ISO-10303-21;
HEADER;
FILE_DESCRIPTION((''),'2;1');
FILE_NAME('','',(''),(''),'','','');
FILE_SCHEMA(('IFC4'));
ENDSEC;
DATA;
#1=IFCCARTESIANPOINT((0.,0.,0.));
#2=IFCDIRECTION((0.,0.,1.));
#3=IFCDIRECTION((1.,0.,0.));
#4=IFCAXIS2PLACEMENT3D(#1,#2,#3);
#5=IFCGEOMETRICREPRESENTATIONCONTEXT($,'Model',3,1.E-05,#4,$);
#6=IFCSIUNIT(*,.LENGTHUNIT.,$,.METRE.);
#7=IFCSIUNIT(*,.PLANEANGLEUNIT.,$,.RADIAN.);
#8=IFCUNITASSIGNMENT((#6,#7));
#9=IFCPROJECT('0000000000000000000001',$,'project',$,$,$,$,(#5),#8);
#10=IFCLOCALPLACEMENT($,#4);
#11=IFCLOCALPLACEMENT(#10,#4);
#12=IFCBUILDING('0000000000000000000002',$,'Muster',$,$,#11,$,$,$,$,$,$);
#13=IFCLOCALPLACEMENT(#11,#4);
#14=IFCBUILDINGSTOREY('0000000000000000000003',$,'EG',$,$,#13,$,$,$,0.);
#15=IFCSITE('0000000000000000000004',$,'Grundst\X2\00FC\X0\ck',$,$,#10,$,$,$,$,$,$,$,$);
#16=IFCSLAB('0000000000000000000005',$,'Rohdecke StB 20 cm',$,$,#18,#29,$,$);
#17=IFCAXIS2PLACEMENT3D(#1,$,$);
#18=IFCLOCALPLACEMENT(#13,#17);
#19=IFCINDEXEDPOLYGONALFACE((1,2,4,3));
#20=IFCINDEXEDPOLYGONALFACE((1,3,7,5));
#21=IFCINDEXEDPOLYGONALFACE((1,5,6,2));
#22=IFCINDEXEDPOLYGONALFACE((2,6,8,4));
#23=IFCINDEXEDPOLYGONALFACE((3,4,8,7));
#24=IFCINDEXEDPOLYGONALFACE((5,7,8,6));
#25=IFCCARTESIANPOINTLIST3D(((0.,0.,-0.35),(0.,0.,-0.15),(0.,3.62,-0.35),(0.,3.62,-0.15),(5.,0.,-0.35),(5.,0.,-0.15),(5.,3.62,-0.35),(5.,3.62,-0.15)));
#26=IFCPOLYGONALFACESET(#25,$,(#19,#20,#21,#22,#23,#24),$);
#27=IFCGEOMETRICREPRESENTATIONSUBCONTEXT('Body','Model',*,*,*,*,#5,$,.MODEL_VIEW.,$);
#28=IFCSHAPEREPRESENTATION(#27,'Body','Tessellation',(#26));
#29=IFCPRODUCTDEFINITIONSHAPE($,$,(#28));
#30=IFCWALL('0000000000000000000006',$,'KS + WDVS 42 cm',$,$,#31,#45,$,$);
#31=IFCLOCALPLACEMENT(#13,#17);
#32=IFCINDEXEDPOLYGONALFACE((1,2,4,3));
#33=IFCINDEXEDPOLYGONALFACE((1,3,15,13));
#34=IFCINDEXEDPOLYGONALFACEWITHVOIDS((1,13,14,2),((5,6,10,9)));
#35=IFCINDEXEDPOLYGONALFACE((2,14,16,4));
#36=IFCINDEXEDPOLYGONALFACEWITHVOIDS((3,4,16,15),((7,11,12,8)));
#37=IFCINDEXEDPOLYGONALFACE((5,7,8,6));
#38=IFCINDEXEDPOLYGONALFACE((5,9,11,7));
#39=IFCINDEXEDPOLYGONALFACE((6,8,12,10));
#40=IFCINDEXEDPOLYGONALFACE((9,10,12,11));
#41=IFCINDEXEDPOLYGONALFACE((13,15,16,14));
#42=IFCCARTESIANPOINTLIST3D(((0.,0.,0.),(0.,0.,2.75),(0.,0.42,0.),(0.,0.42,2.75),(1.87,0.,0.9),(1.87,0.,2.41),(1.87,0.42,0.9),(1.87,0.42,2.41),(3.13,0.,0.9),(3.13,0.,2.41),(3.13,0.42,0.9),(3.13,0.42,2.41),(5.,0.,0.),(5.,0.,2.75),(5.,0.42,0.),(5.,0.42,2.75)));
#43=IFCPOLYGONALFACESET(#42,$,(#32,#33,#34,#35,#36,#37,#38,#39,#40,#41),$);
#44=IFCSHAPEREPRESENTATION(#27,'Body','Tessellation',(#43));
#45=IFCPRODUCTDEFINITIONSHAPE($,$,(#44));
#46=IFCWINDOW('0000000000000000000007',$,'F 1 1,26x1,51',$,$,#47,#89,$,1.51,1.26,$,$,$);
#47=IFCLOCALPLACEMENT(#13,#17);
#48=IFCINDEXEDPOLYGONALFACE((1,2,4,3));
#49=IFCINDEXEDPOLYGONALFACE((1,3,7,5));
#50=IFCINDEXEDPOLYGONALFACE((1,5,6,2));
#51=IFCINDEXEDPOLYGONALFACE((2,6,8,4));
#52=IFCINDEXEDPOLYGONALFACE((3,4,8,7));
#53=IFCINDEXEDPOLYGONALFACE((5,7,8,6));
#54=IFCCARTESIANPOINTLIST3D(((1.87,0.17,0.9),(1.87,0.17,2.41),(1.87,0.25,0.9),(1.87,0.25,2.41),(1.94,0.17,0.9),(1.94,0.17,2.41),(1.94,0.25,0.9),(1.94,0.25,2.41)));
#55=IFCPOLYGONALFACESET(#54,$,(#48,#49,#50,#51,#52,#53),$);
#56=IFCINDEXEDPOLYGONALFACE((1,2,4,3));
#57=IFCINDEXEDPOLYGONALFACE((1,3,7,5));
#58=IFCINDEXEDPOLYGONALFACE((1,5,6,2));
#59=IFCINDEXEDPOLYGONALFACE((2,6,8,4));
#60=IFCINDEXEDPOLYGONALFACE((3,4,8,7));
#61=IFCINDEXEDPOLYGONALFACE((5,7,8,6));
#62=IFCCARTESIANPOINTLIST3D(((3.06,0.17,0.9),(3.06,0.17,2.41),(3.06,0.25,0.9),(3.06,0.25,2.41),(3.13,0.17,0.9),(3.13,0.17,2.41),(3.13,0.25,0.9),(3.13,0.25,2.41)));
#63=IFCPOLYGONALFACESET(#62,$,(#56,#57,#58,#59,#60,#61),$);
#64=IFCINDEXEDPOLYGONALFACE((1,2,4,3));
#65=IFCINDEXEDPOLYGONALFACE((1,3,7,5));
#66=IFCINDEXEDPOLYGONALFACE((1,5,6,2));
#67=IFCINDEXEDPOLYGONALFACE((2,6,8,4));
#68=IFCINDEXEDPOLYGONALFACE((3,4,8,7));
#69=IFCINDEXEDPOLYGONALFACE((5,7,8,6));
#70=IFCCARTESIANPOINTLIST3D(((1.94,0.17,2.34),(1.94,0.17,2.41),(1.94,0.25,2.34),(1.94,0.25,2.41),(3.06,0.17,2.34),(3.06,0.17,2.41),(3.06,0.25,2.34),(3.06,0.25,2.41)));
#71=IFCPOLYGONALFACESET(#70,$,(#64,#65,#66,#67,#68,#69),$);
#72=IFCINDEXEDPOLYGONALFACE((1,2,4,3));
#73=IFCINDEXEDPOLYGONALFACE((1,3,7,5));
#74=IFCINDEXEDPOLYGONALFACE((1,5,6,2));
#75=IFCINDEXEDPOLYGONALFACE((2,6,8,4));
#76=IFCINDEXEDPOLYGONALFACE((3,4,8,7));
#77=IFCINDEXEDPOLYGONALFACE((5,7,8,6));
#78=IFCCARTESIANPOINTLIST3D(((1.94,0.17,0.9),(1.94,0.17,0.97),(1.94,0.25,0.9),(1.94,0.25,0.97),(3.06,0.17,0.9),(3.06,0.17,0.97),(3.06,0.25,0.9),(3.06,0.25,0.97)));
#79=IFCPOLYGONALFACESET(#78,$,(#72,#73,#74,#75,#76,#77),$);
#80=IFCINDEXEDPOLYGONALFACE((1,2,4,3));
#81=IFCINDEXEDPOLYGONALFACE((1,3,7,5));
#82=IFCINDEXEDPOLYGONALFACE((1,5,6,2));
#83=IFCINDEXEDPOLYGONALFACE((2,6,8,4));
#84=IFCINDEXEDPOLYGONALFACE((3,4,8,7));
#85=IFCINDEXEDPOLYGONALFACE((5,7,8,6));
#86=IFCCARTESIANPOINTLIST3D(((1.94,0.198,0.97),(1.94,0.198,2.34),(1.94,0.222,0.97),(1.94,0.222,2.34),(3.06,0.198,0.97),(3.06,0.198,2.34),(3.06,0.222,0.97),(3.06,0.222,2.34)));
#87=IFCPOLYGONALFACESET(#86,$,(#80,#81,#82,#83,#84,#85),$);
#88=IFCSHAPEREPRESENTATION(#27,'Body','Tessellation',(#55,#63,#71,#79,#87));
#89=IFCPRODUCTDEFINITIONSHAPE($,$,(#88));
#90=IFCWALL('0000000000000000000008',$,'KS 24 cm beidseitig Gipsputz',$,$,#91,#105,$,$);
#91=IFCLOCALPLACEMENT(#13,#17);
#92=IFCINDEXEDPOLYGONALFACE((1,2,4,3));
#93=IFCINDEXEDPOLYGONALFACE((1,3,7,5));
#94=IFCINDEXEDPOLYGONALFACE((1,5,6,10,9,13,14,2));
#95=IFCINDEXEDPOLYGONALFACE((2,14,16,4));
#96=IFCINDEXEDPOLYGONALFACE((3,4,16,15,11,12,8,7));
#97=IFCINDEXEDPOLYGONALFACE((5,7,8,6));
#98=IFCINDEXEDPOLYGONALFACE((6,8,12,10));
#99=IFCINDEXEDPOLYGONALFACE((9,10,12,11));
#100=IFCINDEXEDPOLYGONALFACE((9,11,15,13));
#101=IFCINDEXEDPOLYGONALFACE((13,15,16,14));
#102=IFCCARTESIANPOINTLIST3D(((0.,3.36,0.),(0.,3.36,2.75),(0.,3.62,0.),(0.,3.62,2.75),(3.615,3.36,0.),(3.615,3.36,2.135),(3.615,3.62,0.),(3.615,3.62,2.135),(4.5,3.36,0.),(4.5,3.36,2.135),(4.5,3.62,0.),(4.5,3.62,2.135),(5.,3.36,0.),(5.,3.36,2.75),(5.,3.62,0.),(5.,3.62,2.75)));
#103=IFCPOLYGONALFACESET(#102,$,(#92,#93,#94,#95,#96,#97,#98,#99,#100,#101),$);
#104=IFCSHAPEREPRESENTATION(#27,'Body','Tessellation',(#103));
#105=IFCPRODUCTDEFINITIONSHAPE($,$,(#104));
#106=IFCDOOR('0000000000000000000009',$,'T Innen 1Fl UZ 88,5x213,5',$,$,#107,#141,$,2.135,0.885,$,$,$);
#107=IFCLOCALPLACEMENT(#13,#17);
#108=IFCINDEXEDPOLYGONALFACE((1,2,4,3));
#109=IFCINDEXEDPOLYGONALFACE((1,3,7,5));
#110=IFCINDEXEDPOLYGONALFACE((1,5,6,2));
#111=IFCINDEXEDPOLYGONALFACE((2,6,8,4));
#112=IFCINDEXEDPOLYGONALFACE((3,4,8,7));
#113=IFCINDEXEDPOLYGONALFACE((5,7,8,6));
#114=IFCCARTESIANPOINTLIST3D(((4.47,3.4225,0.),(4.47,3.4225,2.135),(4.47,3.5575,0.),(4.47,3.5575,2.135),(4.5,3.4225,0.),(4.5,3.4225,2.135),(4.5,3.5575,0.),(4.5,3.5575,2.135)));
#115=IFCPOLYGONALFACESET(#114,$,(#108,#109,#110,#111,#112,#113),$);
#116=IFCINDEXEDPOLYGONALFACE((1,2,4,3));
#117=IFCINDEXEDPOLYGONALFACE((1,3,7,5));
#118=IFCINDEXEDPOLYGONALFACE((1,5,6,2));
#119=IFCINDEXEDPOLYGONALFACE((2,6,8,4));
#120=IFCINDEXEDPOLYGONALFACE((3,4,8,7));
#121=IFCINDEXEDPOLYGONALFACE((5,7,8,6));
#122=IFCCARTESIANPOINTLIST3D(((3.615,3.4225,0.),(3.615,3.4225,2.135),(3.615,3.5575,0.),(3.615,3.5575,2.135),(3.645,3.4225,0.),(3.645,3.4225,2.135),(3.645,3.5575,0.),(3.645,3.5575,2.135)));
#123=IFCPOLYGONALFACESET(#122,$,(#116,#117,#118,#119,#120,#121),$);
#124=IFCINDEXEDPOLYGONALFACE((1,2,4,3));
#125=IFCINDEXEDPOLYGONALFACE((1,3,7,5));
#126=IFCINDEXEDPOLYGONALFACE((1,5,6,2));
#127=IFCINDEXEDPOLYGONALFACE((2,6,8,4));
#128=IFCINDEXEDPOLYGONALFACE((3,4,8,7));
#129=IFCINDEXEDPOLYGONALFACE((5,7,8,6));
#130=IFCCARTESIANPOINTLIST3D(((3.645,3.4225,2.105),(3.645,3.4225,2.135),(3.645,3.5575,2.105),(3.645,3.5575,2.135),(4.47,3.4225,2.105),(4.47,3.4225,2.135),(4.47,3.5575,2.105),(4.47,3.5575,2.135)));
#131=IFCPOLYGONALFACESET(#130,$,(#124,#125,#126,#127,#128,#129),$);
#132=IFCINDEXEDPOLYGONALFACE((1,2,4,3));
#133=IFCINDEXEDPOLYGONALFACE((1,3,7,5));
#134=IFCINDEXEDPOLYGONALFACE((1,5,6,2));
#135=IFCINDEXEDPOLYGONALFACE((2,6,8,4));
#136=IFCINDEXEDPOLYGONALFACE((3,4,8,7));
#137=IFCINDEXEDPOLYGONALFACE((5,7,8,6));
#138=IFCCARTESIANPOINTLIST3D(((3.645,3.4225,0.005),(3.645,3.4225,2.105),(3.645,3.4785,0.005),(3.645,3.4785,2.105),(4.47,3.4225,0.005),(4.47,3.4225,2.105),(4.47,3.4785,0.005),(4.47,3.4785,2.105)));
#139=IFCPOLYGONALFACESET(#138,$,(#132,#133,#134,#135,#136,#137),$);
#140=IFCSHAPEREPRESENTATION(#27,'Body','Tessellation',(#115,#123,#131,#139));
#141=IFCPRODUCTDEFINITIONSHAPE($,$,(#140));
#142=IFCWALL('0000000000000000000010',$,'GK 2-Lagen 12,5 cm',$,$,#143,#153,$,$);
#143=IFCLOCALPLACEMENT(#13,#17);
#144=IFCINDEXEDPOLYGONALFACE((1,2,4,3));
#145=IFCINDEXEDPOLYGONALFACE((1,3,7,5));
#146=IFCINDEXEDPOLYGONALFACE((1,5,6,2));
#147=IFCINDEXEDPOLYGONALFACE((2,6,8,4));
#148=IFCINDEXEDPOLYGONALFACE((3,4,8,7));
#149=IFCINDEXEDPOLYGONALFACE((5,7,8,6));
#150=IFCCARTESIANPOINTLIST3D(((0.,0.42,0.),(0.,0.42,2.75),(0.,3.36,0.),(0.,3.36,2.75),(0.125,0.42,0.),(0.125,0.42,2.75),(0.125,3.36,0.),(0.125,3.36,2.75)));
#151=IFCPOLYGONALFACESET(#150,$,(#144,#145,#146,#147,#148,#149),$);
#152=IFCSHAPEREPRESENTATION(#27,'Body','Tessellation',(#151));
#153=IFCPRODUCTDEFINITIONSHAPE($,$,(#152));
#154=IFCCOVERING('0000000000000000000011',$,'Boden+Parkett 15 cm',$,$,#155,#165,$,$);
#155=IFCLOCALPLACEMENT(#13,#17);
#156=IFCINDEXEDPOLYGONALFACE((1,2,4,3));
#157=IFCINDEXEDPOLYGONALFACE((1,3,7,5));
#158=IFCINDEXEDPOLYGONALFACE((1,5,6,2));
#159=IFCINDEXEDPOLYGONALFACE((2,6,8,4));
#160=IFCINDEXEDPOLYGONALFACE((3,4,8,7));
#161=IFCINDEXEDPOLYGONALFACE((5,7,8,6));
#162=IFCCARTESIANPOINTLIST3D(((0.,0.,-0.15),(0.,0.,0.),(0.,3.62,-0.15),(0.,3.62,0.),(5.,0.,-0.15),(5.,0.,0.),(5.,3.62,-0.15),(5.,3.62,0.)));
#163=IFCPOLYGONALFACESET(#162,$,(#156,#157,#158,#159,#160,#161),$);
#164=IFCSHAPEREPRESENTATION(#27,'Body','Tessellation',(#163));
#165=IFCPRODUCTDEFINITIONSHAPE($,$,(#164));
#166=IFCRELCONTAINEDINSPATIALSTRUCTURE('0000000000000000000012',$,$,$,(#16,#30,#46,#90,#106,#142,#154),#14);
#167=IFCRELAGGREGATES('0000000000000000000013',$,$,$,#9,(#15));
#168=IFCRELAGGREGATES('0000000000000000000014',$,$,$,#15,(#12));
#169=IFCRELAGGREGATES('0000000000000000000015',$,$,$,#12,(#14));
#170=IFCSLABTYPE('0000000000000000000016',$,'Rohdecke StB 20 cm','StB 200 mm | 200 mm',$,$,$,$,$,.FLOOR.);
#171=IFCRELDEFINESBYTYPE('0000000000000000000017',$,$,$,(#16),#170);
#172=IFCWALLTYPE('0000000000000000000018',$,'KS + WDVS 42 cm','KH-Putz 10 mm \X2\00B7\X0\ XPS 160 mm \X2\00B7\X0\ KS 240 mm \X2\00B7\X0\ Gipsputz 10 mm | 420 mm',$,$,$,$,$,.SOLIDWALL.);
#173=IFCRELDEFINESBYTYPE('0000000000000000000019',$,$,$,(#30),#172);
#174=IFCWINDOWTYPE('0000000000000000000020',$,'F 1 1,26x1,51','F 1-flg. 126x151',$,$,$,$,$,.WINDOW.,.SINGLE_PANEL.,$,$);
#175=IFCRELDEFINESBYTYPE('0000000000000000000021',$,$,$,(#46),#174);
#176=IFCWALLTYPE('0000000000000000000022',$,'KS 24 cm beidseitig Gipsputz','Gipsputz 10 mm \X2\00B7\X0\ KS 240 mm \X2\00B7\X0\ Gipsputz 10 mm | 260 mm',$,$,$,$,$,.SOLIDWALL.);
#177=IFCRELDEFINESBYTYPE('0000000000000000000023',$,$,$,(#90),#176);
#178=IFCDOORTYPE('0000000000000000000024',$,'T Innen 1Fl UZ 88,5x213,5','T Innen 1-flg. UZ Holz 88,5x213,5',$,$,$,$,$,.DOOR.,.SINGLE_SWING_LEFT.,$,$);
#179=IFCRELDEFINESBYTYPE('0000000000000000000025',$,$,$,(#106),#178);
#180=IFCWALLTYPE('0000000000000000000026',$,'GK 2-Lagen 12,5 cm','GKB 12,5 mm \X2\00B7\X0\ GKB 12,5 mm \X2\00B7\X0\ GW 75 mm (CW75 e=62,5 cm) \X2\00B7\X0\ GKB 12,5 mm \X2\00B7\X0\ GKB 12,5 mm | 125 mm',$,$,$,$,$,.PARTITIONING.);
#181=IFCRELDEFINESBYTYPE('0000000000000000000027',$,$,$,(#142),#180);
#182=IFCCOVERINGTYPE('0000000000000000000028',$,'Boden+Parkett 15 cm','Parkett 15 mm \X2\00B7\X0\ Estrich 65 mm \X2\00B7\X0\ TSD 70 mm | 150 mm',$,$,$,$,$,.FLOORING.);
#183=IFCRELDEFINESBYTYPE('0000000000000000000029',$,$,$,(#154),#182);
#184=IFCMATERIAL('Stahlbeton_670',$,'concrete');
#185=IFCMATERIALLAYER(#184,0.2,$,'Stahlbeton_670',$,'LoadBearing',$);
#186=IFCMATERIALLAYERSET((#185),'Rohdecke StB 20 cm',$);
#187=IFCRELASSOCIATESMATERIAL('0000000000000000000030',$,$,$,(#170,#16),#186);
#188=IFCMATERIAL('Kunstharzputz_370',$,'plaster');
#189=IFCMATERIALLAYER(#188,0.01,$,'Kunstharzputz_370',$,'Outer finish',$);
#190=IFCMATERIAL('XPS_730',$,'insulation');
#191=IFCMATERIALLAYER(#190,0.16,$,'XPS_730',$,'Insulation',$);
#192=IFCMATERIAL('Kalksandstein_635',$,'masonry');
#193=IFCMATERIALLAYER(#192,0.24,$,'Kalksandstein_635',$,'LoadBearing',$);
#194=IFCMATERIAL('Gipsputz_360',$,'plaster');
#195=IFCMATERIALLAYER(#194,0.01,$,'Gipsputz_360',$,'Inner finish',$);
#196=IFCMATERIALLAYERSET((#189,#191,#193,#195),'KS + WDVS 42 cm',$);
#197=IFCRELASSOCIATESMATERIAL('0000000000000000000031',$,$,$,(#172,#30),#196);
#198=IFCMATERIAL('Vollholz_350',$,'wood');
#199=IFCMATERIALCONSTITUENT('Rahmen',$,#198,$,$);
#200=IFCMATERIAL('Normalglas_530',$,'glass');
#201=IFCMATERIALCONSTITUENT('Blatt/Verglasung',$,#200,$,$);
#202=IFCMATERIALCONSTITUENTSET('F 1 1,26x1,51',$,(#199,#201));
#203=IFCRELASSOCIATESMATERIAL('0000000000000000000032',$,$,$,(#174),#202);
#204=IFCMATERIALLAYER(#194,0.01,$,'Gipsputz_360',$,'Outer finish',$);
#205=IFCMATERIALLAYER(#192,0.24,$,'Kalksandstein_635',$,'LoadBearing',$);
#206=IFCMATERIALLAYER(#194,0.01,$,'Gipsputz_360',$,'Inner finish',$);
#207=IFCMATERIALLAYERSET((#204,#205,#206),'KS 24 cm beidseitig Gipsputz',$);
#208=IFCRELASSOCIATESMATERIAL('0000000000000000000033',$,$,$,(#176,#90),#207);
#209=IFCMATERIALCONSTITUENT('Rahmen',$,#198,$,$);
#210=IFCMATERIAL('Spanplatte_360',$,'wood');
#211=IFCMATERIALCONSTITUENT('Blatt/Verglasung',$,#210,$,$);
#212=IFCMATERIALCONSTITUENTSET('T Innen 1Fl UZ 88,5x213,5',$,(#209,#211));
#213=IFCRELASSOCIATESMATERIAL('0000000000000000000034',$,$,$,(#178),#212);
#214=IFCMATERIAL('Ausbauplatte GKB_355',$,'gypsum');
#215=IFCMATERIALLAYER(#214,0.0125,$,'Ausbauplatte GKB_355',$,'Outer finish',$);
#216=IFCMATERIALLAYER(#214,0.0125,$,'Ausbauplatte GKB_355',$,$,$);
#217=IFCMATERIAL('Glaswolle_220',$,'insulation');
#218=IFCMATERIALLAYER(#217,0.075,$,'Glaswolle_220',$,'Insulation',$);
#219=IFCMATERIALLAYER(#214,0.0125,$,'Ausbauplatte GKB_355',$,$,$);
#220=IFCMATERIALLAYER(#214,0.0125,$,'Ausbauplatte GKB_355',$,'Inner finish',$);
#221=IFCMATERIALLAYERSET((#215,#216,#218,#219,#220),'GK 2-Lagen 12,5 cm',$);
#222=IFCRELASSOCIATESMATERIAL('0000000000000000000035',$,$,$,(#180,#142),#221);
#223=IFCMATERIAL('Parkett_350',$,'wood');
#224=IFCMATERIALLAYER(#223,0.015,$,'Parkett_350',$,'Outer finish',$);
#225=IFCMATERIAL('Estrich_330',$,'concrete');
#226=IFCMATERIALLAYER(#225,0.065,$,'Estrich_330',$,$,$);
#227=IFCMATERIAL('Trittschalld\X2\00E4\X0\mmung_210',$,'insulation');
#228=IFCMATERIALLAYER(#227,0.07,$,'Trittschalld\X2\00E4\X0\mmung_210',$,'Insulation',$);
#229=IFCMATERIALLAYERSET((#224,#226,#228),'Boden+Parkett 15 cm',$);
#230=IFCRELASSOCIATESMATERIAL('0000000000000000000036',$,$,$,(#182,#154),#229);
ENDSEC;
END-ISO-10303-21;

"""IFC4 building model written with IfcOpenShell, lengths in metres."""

from ifc_helpers import new_model, si_unit, frame, frame_2d, origin, origin_with_axes, place, context, subcontext, project, spatial, rectangle, extrude, source, transform, mapped, material, layer, layer_set, layer_usage, constituent, constituent_set, type_object, type_shapes, element, fill, save


model = new_model("IFC4")

# Units and contexts
model_context = context("Model", 3, precision=1e-05, world=origin_with_axes())
body_context = subcontext(model_context, "Body", "Model", "MODEL_VIEW")
ifc_project = project(units=[si_unit("LENGTHUNIT", "METRE"), si_unit("PLANEANGLEUNIT", "RADIAN")], contexts=[model_context])

# Site, building, storey
site_placement = place(None, origin_with_axes())
site = spatial("IfcSite", under=ifc_project, at=site_placement, Name="Grundstück")
building_placement = place(site_placement, origin_with_axes())
building = spatial("IfcBuilding", under=site, at=building_placement, Name="Muster")
storey_placement = place(building_placement, origin_with_axes())
storey = spatial("IfcBuildingStorey", under=building, at=storey_placement, Name="EG", Elevation=0.0)

# Slab
ifc_material_1 = material(Name="Stahlbeton_670", Category="concrete")
ifc_layer_1 = layer(ifc_material_1, 0.2, Name="Stahlbeton_670", Category="LoadBearing")
ifc_layer_set_1 = layer_set([ifc_layer_1], Name="Rohdecke StB 20 cm")
ifc_layer_usage_1 = layer_usage(ifc_layer_set_1, "AXIS3", "NEGATIVE", 0.0)
slab_type = type_object("IfcSlabType", Name="Rohdecke StB 20 cm", Description="StB 200 mm | 200 mm", PredefinedType="FLOOR", material=ifc_layer_set_1)
slab_placement = place(storey_placement, frame((0.0, 0.0, -0.15), z_axis=(0.0, 0.0, 1.0), x_axis=(1.0, 0.0, 0.0)))
element("IfcSlab", 1, at=slab_placement, inside=storey, type_object=slab_type, material=ifc_layer_usage_1, Name="Rohdecke StB 20 cm", context=body_context, shape_type="SweptSolid", body=[
    extrude(rectangle(XDim=5.0, YDim=3.62, at=frame_2d((2.5, 1.81))), origin(), (0.0, 0.0, -1.0), 0.2),
])

# Wall, opening, window
ifc_material_2 = material(Name="Kunstharzputz_370", Category="plaster")
ifc_layer_2 = layer(ifc_material_2, 0.01, Name="Kunstharzputz_370", Category="Outer finish")
ifc_material_3 = material(Name="XPS_730", Category="insulation")
ifc_layer_3 = layer(ifc_material_3, 0.16, Name="XPS_730", Category="Insulation")
ifc_material_4 = material(Name="Kalksandstein_635", Category="masonry")
ifc_layer_4 = layer(ifc_material_4, 0.24, Name="Kalksandstein_635", Category="LoadBearing")
ifc_material_5 = material(Name="Gipsputz_360", Category="plaster")
ifc_layer_5 = layer(ifc_material_5, 0.01, Name="Gipsputz_360", Category="Inner finish")
ifc_layer_set_2 = layer_set([ifc_layer_2, ifc_layer_3, ifc_layer_4, ifc_layer_5], Name="KS + WDVS 42 cm")
ifc_layer_usage_2 = layer_usage(ifc_layer_set_2, "AXIS2", "POSITIVE", 0.0)
wall_type_1 = type_object("IfcWallType", Name="KS + WDVS 42 cm", Description="KH-Putz 10 mm · XPS 160 mm · KS 240 mm · Gipsputz 10 mm | 420 mm", PredefinedType="SOLIDWALL", material=ifc_layer_set_2)
wall_1_placement = place(storey_placement, origin_with_axes())
wall_1 = element("IfcWall", 2, at=wall_1_placement, inside=storey, type_object=wall_type_1, material=ifc_layer_usage_2, Name="KS + WDVS 42 cm", context=body_context, shape_type="SweptSolid", body=[
    extrude(rectangle(XDim=5.0, YDim=0.42, at=frame_2d((2.5, 0.21))), origin(), (0.0, 0.0, 1.0), 2.75),
])
opening_1_placement = place(wall_1_placement, frame((1.87, 0.0, 0.9), z_axis=(0.0, 0.0, 1.0), x_axis=(1.0, 0.0, 0.0)))
opening_1 = element("IfcOpeningElement", 3, at=opening_1_placement, cuts=wall_1, PredefinedType="OPENING", context=body_context, shape_type="SweptSolid", body=[
    extrude(rectangle(XDim=1.26, YDim=0.44, at=frame_2d((0.63, 0.21))), origin(), (0.0, 0.0, 1.0), 1.51),
])
ifc_material_6 = material(Name="Vollholz_350", Category="wood")
ifc_constituent_1 = constituent(ifc_material_6, Name="Rahmen")
ifc_material_7 = material(Name="Normalglas_530", Category="glass")
ifc_constituent_2 = constituent(ifc_material_7, Name="Blatt/Verglasung")
ifc_constituent_set_1 = constituent_set(constituents=[ifc_constituent_1, ifc_constituent_2], Name="F 1 1,26x1,51")
window_type = type_object("IfcWindowType", Name="F 1 1,26x1,51", Description="F 1-flg. 126x151", PartitioningType="SINGLE_PANEL", PredefinedType="WINDOW", material=ifc_constituent_set_1)
shared_shape_1 = source(origin(), body_context, "Body", "SweptSolid", [
    extrude(rectangle(XDim=0.07, YDim=0.08, at=frame_2d((0.035, 0.04))), origin(), (0.0, 0.0, 1.0), 1.51),
    extrude(rectangle(XDim=0.07, YDim=0.08, at=frame_2d((1.225, 0.04))), origin(), (0.0, 0.0, 1.0), 1.51),
    extrude(rectangle(XDim=1.12, YDim=0.08, at=frame_2d((0.63, 0.04))), frame((0.0, 0.0, 1.44)), (0.0, 0.0, 1.0), 0.07),
    extrude(rectangle(XDim=1.12, YDim=0.08, at=frame_2d((0.63, 0.04))), origin(), (0.0, 0.0, 1.0), 0.07),
    extrude(rectangle(XDim=1.12, YDim=0.024, at=frame_2d((0.63, 0.04))), frame((0.0, 0.0, 0.07)), (0.0, 0.0, 1.0), 1.37),
])
type_shapes(window_type, [shared_shape_1])
window_placement = place(opening_1_placement, origin_with_axes())
window = element("IfcWindow", 4, at=window_placement, inside=storey, type_object=window_type, Name="F 1 1,26x1,51", OverallHeight=1.51, OverallWidth=1.26, context=body_context, shape_type="MappedRepresentation", body=[
    mapped(shared_shape_1, transform((0.0, 0.17, 0.0))),
])
fill(opening_1, window)

# Wall, opening, door
ifc_layer_6 = layer(ifc_material_5, 0.01, Name="Gipsputz_360", Category="Outer finish")
ifc_layer_7 = layer(ifc_material_4, 0.24, Name="Kalksandstein_635", Category="LoadBearing")
ifc_layer_8 = layer(ifc_material_5, 0.01, Name="Gipsputz_360", Category="Inner finish")
ifc_layer_set_3 = layer_set([ifc_layer_6, ifc_layer_7, ifc_layer_8], Name="KS 24 cm beidseitig Gipsputz")
ifc_layer_usage_3 = layer_usage(ifc_layer_set_3, "AXIS2", "POSITIVE", 0.0)
wall_type_2 = type_object("IfcWallType", Name="KS 24 cm beidseitig Gipsputz", Description="Gipsputz 10 mm · KS 240 mm · Gipsputz 10 mm | 260 mm", PredefinedType="SOLIDWALL", material=ifc_layer_set_3)
wall_2_placement = place(storey_placement, frame((5.0, 3.62, 0.0), z_axis=(0.0, 0.0, 1.0), x_axis=(-1.0, 0.0, 0.0)))
wall_2 = element("IfcWall", 5, at=wall_2_placement, inside=storey, type_object=wall_type_2, material=ifc_layer_usage_3, Name="KS 24 cm beidseitig Gipsputz", context=body_context, shape_type="SweptSolid", body=[
    extrude(rectangle(XDim=5.0, YDim=0.26, at=frame_2d((2.5, 0.13))), origin(), (0.0, 0.0, 1.0), 2.75),
])
opening_2_placement = place(wall_2_placement, frame((0.5, 0.0, 0.0), z_axis=(0.0, 0.0, 1.0), x_axis=(1.0, 0.0, 0.0)))
opening_2 = element("IfcOpeningElement", 6, at=opening_2_placement, cuts=wall_2, PredefinedType="OPENING", context=body_context, shape_type="SweptSolid", body=[
    extrude(rectangle(XDim=0.885, YDim=0.28, at=frame_2d((0.4425, 0.13))), origin(), (0.0, 0.0, 1.0), 2.135),
])
ifc_constituent_3 = constituent(ifc_material_6, Name="Rahmen")
ifc_material_8 = material(Name="Spanplatte_360", Category="wood")
ifc_constituent_4 = constituent(ifc_material_8, Name="Blatt/Verglasung")
ifc_constituent_set_2 = constituent_set(constituents=[ifc_constituent_3, ifc_constituent_4], Name="T Innen 1Fl UZ 88,5x213,5")
door_type = type_object("IfcDoorType", Name="T Innen 1Fl UZ 88,5x213,5", Description="T Innen 1-flg. UZ Holz 88,5x213,5", OperationType="SINGLE_SWING_LEFT", PredefinedType="DOOR", material=ifc_constituent_set_2)
shared_shape_2 = source(origin(), body_context, "Body", "SweptSolid", [
    extrude(rectangle(XDim=0.03, YDim=0.135, at=frame_2d((0.015, 0.0675))), origin(), (0.0, 0.0, 1.0), 2.135),
    extrude(rectangle(XDim=0.03, YDim=0.135, at=frame_2d((0.87, 0.0675))), origin(), (0.0, 0.0, 1.0), 2.135),
    extrude(rectangle(XDim=0.825, YDim=0.135, at=frame_2d((0.4425, 0.0675))), frame((0.0, 0.0, 2.105)), (0.0, 0.0, 1.0), 0.03),
    extrude(rectangle(XDim=0.825, YDim=0.056, at=frame_2d((0.4425, 0.107))), frame((0.0, 0.0, 0.005)), (0.0, 0.0, 1.0), 2.1),
])
type_shapes(door_type, [shared_shape_2])
door_placement = place(opening_2_placement, origin_with_axes())
door = element("IfcDoor", 7, at=door_placement, inside=storey, type_object=door_type, Name="T Innen 1Fl UZ 88,5x213,5", OverallHeight=2.135, OverallWidth=0.885, context=body_context, shape_type="MappedRepresentation", body=[
    mapped(shared_shape_2, transform((0.0, 0.0625, 0.0))),
])
fill(opening_2, door)

# Wall
ifc_material_9 = material(Name="Ausbauplatte GKB_355", Category="gypsum")
ifc_layer_9 = layer(ifc_material_9, 0.0125, Name="Ausbauplatte GKB_355", Category="Outer finish")
ifc_layer_10 = layer(ifc_material_9, 0.0125, Name="Ausbauplatte GKB_355")
ifc_material_10 = material(Name="Glaswolle_220", Category="insulation")
ifc_layer_11 = layer(ifc_material_10, 0.075, Name="Glaswolle_220", Category="Insulation")
ifc_layer_12 = layer(ifc_material_9, 0.0125, Name="Ausbauplatte GKB_355")
ifc_layer_13 = layer(ifc_material_9, 0.0125, Name="Ausbauplatte GKB_355", Category="Inner finish")
ifc_layer_set_4 = layer_set([ifc_layer_9, ifc_layer_10, ifc_layer_11, ifc_layer_12, ifc_layer_13], Name="GK 2-Lagen 12,5 cm")
ifc_layer_usage_4 = layer_usage(ifc_layer_set_4, "AXIS2", "POSITIVE", 0.0)
wall_type_3 = type_object("IfcWallType", Name="GK 2-Lagen 12,5 cm", Description="GKB 12,5 mm · GKB 12,5 mm · GW 75 mm (CW75 e=62,5 cm) · GKB 12,5 mm · GKB 12,5 mm | 125 mm", PredefinedType="PARTITIONING", material=ifc_layer_set_4)
wall_3_placement = place(storey_placement, frame((0.0, 3.36, 0.0), z_axis=(0.0, 0.0, 1.0), x_axis=(0.0, -1.0, 0.0)))
element("IfcWall", 8, at=wall_3_placement, inside=storey, type_object=wall_type_3, material=ifc_layer_usage_4, Name="GK 2-Lagen 12,5 cm", context=body_context, shape_type="SweptSolid", body=[
    extrude(rectangle(XDim=2.94, YDim=0.125, at=frame_2d((1.47, 0.0625))), origin(), (0.0, 0.0, 1.0), 2.75),
])

# Covering
ifc_material_11 = material(Name="Parkett_350", Category="wood")
ifc_layer_14 = layer(ifc_material_11, 0.015, Name="Parkett_350", Category="Outer finish")
ifc_material_12 = material(Name="Estrich_330", Category="concrete")
ifc_layer_15 = layer(ifc_material_12, 0.065, Name="Estrich_330")
ifc_material_13 = material(Name="Trittschalldämmung_210", Category="insulation")
ifc_layer_16 = layer(ifc_material_13, 0.07, Name="Trittschalldämmung_210", Category="Insulation")
ifc_layer_set_5 = layer_set([ifc_layer_14, ifc_layer_15, ifc_layer_16], Name="Boden+Parkett 15 cm")
ifc_layer_usage_5 = layer_usage(ifc_layer_set_5, "AXIS3", "NEGATIVE", 0.0)
covering_type = type_object("IfcCoveringType", Name="Boden+Parkett 15 cm", Description="Parkett 15 mm · Estrich 65 mm · TSD 70 mm | 150 mm", PredefinedType="FLOORING", material=ifc_layer_set_5)
covering_placement = place(storey_placement, origin_with_axes())
element("IfcCovering", 9, at=covering_placement, inside=storey, type_object=covering_type, material=ifc_layer_usage_5, Name="Boden+Parkett 15 cm", context=body_context, shape_type="SweptSolid", body=[
    extrude(rectangle(XDim=5.0, YDim=3.62, at=frame_2d((2.5, 1.81))), origin(), (0.0, 0.0, -1.0), 0.15),
])

save(model, "model.ifc")
